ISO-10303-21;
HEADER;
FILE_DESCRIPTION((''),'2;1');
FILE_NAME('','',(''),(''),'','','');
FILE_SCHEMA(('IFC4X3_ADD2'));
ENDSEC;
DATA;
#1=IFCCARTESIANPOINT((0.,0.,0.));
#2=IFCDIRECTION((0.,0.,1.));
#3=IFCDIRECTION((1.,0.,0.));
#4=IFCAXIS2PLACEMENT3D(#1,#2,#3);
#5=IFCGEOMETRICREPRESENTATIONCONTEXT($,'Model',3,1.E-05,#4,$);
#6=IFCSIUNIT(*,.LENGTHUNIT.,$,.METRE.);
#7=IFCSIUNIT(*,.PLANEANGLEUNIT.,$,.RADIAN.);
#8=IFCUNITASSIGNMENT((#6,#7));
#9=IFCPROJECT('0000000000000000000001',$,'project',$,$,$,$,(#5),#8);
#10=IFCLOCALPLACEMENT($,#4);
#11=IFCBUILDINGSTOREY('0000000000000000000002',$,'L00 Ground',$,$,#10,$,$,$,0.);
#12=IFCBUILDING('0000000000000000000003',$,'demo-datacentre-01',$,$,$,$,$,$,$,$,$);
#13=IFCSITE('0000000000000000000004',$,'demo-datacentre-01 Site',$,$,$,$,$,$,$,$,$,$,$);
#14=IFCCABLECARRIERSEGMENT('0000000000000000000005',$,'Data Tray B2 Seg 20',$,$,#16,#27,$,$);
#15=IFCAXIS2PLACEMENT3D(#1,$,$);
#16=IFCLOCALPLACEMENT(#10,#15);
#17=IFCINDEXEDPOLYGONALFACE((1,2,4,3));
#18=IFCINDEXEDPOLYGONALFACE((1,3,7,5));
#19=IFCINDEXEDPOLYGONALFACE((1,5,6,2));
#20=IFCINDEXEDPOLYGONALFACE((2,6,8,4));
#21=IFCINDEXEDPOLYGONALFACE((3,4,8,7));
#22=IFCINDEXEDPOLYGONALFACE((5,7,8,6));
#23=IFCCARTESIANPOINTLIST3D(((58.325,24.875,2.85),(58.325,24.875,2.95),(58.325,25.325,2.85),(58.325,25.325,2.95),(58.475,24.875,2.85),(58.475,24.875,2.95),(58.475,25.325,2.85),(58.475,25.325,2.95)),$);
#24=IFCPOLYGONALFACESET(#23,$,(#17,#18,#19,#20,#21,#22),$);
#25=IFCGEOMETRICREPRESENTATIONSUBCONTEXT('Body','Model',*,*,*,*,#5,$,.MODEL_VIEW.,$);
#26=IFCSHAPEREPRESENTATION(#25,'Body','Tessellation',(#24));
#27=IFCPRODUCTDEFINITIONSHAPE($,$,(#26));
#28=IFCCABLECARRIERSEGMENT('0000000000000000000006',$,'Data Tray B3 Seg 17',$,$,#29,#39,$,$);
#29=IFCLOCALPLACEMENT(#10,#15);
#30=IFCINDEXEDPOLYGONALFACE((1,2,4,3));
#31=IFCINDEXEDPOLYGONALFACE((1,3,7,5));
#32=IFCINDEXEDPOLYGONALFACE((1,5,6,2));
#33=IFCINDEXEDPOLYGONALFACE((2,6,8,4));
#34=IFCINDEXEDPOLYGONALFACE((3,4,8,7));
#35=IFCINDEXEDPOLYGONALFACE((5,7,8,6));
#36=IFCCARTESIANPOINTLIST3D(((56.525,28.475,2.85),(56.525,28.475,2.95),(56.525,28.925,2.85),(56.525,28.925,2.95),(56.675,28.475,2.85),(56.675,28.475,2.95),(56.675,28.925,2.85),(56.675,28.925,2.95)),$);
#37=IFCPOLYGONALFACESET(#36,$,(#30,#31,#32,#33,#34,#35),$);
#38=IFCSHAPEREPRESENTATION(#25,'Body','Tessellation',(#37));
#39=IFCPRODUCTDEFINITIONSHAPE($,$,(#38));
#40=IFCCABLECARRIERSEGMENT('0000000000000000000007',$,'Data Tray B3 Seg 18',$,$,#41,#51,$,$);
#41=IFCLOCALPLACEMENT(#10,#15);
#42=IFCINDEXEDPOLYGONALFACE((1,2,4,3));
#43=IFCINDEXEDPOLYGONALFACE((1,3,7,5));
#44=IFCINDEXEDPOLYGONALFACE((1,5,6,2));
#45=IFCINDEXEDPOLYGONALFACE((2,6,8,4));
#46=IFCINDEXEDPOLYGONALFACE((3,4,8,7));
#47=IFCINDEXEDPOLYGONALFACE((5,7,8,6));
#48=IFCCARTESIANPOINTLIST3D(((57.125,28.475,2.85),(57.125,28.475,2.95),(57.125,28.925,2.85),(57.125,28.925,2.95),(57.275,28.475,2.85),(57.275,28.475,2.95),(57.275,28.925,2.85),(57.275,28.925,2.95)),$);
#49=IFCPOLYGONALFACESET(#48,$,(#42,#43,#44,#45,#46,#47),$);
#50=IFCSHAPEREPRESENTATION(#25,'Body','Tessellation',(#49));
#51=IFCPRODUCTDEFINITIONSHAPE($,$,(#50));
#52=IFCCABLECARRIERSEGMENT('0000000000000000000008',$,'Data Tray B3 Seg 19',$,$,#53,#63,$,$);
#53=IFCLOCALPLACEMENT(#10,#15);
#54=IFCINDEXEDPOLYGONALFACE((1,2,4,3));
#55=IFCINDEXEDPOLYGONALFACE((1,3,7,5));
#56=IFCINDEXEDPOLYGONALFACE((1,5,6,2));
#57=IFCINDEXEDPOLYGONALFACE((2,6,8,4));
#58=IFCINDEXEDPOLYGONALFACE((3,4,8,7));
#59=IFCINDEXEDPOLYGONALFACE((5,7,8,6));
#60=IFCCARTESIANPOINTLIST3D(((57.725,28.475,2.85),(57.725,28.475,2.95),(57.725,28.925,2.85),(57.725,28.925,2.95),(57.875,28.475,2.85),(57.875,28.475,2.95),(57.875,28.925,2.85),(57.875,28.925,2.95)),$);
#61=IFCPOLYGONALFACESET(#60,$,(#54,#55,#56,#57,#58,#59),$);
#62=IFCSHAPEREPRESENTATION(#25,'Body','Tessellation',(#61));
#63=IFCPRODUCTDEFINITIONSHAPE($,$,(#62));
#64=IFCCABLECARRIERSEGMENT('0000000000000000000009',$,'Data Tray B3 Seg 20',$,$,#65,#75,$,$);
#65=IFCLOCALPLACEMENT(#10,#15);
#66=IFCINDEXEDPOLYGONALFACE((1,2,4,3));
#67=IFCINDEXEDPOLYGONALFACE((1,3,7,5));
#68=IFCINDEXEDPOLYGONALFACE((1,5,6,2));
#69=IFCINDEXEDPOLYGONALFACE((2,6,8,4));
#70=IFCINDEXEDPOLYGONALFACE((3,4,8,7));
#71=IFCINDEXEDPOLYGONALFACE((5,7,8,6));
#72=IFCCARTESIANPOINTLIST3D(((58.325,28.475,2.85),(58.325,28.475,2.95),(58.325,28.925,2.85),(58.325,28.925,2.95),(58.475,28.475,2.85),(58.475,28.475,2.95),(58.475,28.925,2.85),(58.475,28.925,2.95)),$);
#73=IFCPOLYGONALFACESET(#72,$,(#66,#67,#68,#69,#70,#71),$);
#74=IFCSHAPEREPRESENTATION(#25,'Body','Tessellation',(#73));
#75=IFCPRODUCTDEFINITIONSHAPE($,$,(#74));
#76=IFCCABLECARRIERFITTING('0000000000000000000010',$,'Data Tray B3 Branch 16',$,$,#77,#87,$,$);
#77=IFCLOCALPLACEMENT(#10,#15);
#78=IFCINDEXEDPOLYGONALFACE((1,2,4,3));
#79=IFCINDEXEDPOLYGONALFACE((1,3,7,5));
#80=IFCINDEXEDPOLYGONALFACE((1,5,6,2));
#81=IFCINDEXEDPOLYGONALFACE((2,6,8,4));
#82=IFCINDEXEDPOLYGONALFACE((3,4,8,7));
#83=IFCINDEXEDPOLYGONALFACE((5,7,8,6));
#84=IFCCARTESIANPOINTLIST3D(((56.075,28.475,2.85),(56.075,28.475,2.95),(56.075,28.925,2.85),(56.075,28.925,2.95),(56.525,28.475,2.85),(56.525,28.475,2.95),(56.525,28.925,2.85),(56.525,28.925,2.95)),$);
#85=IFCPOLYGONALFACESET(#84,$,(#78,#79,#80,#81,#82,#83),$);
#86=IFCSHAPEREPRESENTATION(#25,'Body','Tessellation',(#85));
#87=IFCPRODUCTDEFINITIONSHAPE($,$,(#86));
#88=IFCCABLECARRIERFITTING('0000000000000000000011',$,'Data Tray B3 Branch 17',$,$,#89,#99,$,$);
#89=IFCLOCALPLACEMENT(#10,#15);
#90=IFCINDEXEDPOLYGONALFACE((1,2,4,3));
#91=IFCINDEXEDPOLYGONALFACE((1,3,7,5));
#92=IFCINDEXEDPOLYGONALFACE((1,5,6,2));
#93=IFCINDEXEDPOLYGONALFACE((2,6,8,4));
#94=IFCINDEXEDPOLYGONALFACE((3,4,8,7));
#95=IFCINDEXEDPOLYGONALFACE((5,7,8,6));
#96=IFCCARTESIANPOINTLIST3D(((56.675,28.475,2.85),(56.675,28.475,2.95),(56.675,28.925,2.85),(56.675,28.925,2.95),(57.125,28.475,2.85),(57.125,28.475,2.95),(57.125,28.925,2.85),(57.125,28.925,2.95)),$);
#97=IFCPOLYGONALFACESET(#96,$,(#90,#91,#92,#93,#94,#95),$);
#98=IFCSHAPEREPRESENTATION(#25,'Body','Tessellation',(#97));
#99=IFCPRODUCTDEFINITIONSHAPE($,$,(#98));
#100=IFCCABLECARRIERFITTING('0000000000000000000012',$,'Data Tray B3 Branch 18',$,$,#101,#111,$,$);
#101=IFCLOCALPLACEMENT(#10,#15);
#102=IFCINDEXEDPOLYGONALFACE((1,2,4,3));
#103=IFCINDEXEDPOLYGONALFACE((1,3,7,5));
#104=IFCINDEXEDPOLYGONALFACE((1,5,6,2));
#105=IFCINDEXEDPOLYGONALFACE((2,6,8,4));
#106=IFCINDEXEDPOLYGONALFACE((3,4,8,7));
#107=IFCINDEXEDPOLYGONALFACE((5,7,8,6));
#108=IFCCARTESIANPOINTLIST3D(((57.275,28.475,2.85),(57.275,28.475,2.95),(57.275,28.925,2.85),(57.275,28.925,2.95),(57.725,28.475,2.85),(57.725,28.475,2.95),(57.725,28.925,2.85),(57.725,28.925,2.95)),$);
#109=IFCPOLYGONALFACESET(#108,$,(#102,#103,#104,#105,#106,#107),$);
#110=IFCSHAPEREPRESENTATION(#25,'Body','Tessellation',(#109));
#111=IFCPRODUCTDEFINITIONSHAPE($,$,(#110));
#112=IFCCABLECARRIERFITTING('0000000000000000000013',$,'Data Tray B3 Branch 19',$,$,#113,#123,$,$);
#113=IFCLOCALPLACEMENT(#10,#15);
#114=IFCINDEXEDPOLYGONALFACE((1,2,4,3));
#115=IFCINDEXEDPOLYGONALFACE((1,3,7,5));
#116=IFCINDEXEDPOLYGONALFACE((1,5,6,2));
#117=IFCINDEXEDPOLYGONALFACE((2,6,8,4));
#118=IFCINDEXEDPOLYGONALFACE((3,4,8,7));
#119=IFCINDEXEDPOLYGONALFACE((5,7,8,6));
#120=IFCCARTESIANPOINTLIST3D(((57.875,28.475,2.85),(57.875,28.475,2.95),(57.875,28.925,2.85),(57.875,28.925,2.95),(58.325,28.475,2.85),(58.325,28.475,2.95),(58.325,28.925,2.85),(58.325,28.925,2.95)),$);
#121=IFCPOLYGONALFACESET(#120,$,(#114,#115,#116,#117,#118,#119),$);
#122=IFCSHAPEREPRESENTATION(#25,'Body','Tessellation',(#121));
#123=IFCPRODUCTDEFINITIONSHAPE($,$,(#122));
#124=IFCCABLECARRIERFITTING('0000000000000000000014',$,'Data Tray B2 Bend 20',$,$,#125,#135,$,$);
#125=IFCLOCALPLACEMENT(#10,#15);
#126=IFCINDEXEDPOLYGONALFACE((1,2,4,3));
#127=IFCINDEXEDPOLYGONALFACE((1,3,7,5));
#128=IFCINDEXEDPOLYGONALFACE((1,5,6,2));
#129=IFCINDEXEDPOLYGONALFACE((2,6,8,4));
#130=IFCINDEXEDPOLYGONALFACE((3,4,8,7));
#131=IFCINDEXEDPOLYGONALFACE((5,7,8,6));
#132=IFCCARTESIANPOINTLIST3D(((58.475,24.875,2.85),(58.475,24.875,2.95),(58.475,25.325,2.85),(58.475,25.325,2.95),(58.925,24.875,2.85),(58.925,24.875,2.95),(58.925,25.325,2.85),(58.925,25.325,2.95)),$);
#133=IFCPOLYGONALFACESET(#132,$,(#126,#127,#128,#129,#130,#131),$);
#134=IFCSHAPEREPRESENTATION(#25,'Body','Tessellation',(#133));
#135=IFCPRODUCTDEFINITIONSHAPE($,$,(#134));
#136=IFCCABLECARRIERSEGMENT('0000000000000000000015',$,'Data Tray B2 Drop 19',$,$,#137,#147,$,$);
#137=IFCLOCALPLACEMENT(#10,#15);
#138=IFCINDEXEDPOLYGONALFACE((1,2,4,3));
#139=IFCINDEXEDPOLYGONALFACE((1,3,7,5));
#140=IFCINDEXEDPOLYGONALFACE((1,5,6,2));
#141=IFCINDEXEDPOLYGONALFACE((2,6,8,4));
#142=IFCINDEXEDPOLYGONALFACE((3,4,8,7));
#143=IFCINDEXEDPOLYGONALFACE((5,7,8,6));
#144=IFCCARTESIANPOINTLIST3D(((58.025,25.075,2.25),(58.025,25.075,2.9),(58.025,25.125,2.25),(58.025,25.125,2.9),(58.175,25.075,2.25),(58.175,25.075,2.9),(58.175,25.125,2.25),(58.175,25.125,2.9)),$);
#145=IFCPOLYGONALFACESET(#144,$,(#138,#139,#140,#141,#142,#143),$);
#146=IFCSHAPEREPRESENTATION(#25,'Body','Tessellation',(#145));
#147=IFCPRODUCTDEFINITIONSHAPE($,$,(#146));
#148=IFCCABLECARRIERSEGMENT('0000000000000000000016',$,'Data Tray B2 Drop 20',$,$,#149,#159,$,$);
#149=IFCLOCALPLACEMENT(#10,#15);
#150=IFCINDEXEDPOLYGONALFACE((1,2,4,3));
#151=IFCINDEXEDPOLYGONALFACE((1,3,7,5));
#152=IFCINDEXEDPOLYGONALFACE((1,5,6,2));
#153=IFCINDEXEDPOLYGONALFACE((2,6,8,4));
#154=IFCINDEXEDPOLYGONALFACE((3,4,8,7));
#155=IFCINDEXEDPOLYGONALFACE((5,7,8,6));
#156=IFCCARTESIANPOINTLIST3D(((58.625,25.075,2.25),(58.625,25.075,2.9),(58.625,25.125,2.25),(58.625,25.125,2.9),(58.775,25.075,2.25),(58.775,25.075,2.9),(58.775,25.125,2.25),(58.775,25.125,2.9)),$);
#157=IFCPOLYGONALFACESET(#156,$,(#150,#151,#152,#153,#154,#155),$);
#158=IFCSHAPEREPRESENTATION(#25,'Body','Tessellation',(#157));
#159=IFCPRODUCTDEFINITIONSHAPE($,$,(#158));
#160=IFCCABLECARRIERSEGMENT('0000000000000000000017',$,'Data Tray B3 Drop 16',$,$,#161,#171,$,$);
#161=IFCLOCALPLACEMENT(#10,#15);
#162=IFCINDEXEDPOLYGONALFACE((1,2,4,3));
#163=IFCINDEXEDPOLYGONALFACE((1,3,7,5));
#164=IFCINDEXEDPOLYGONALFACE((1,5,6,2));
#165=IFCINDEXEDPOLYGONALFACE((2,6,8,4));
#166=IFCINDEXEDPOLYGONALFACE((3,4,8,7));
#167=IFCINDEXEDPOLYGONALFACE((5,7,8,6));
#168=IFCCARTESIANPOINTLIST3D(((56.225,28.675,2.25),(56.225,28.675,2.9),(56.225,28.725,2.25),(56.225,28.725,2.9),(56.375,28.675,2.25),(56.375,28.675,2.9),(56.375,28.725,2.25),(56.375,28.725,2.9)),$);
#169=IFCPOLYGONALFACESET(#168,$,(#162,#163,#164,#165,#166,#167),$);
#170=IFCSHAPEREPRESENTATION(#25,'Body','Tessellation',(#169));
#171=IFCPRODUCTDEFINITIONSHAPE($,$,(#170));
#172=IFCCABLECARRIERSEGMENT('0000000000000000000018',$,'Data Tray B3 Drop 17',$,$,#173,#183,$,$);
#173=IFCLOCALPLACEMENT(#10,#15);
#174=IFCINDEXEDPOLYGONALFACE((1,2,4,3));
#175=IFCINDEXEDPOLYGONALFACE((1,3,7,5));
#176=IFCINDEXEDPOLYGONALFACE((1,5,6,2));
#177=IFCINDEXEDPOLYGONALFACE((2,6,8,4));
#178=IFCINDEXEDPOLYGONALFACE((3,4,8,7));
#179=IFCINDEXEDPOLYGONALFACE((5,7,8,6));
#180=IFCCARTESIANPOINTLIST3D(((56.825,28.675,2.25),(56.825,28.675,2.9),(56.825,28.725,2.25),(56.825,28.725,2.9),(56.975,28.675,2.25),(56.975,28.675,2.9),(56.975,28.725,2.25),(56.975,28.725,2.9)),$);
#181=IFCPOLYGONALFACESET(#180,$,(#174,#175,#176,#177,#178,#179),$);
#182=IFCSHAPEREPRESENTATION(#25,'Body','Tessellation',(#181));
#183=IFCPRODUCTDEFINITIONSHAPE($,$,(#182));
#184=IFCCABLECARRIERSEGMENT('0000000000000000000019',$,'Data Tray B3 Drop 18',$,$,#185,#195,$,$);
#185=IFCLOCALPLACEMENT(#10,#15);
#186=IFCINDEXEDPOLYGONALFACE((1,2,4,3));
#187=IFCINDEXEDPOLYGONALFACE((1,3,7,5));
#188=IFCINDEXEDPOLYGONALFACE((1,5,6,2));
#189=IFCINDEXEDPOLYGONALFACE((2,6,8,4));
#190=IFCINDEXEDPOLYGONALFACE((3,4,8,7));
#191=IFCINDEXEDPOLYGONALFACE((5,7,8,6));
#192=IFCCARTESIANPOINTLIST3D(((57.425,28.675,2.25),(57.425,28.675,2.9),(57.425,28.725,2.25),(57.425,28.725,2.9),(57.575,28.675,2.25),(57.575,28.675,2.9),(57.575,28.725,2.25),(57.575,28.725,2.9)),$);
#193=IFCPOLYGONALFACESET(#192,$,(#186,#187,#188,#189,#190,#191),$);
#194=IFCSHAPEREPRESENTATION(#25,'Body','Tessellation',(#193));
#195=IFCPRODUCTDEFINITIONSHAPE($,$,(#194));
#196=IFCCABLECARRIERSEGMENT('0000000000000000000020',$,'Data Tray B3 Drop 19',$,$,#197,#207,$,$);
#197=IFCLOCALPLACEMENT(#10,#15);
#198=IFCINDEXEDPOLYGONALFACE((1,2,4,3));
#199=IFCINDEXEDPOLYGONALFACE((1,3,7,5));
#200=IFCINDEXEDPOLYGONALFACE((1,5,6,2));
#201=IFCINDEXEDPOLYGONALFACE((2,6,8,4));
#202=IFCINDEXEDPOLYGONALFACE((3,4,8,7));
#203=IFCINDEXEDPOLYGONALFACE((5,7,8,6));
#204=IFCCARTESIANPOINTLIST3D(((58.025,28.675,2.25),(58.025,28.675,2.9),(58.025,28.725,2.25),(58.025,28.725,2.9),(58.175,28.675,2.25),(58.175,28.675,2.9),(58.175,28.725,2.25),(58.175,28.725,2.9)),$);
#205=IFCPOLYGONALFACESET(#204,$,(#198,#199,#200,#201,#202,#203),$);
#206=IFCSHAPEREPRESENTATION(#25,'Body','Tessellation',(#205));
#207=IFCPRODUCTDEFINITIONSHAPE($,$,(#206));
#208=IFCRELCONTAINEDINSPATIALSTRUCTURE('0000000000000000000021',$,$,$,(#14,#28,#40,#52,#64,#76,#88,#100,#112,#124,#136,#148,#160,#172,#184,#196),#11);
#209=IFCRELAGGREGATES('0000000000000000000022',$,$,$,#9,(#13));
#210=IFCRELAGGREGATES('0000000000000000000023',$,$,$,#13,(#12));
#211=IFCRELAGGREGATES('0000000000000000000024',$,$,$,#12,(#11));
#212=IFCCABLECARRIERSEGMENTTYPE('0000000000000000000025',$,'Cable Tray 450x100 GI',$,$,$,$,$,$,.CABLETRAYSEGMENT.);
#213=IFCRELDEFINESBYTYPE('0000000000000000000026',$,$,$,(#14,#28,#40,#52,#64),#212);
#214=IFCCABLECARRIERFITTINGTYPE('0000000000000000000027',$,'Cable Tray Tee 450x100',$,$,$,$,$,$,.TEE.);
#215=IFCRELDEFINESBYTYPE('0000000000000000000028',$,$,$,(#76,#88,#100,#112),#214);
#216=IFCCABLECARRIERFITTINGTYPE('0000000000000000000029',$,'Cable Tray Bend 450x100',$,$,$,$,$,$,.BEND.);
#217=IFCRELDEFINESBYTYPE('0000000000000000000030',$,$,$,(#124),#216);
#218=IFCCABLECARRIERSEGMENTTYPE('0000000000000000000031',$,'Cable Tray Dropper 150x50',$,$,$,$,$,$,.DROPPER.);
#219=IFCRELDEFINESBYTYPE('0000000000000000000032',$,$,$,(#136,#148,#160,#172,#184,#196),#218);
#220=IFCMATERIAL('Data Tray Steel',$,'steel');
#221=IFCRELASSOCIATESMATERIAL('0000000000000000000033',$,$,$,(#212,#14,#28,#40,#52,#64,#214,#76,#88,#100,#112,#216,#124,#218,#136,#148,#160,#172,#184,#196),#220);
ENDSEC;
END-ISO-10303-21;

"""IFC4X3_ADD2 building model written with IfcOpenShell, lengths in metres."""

from ifc_helpers import new_model, si_unit, frame, origin_with_axes, place, context, subcontext, project, spatial, rectangle, extrude, material, type_object, element, save


model = new_model("IFC4X3_ADD2")

# Units and contexts
model_context = context("Model", 3, precision=1e-05, world=origin_with_axes())
body_context = subcontext(model_context, "Body", "Model", "MODEL_VIEW")
ifc_project = project(units=[si_unit("LENGTHUNIT", "METRE"), si_unit("PLANEANGLEUNIT", "RADIAN")], contexts=[model_context])

# Site, building, storey
site = spatial("IfcSite", under=ifc_project, Name="demo-datacentre-01 Site")
building = spatial("IfcBuilding", under=site, Name="demo-datacentre-01")
storey_placement = place(None, origin_with_axes())
storey = spatial("IfcBuildingStorey", under=building, at=storey_placement, Name="L00 Ground", Elevation=0.0)

# Cable carrier segments
ifc_material_1 = material(Name="Data Tray Steel", Category="steel")
cable_carrier_segment_type_1 = type_object("IfcCableCarrierSegmentType", Name="Cable Tray 450x100 GI", PredefinedType="CABLETRAYSEGMENT", material=ifc_material_1)
for number, where, z_axis, x_axis, name in (
    (1, (58.325, 25.1, 2.9), (1.0, 0.0, 0.0), (0.0, 1.0, 0.0), "Data Tray B2 Seg 20"),
    (2, (56.525, 28.7, 2.9), (1.0, 0.0, 0.0), (0.0, 1.0, 0.0), "Data Tray B3 Seg 17"),
    (3, (57.125, 28.7, 2.9), (1.0, 0.0, 0.0), (0.0, 1.0, 0.0), "Data Tray B3 Seg 18"),
):
    element("IfcCableCarrierSegment", number, at=place(storey_placement, frame(where, z_axis=z_axis, x_axis=x_axis)), inside=storey, type_object=cable_carrier_segment_type_1, material=ifc_material_1, Name=name, context=body_context, shape_type="SweptSolid", body=[
        extrude(rectangle(XDim=0.45, YDim=0.1), origin_with_axes(), (0.0, 0.0, 1.0), 0.15),
    ])
cable_carrier_segment_1_placement = place(storey_placement, frame((57.725, 28.7, 2.9), z_axis=(1.0, 0.0, 0.0), x_axis=(0.0, 1.0, 0.0)))
element("IfcCableCarrierSegment", 4, at=cable_carrier_segment_1_placement, inside=storey, type_object=cable_carrier_segment_type_1, material=ifc_material_1, Name="Data Tray B3 Seg 19", context=body_context, shape_type="SweptSolid", body=[
    extrude(rectangle(XDim=0.45, YDim=0.1), origin_with_axes(), (0.0, 0.0, 1.0), 0.15),
])
cable_carrier_segment_2_placement = place(storey_placement, frame((58.325, 28.7, 2.9), z_axis=(1.0, 0.0, 0.0), x_axis=(0.0, 1.0, 0.0)))
element("IfcCableCarrierSegment", 5, at=cable_carrier_segment_2_placement, inside=storey, type_object=cable_carrier_segment_type_1, material=ifc_material_1, Name="Data Tray B3 Seg 20", context=body_context, shape_type="SweptSolid", body=[
    extrude(rectangle(XDim=0.45, YDim=0.1), origin_with_axes(), (0.0, 0.0, 1.0), 0.15),
])

# Cable carrier fittings
cable_carrier_fitting_type_1 = type_object("IfcCableCarrierFittingType", Name="Cable Tray Tee 450x100", PredefinedType="TEE", material=ifc_material_1)
for number, where, z_axis, x_axis, name in (
    (6, (56.3, 28.7, 2.85), (0.0, 0.0, 1.0), (1.0, 0.0, 0.0), "Data Tray B3 Branch 16"),
    (7, (56.9, 28.7, 2.85), (0.0, 0.0, 1.0), (1.0, 0.0, 0.0), "Data Tray B3 Branch 17"),
    (8, (57.5, 28.7, 2.85), (0.0, 0.0, 1.0), (1.0, 0.0, 0.0), "Data Tray B3 Branch 18"),
    (9, (58.1, 28.7, 2.85), (0.0, 0.0, 1.0), (1.0, 0.0, 0.0), "Data Tray B3 Branch 19"),
):
    element("IfcCableCarrierFitting", number, at=place(storey_placement, frame(where, z_axis=z_axis, x_axis=x_axis)), inside=storey, type_object=cable_carrier_fitting_type_1, material=ifc_material_1, Name=name, context=body_context, shape_type="SweptSolid", body=[
        extrude(rectangle(XDim=0.45, YDim=0.45), origin_with_axes(), (0.0, 0.0, 1.0), 0.1),
    ])
cable_carrier_fitting_type_2 = type_object("IfcCableCarrierFittingType", Name="Cable Tray Bend 450x100", PredefinedType="BEND", material=ifc_material_1)
cable_carrier_fitting_placement = place(storey_placement, frame((58.7, 25.1, 2.85), z_axis=(0.0, 0.0, 1.0), x_axis=(1.0, 0.0, 0.0)))
element("IfcCableCarrierFitting", 10, at=cable_carrier_fitting_placement, inside=storey, type_object=cable_carrier_fitting_type_2, material=ifc_material_1, Name="Data Tray B2 Bend 20", context=body_context, shape_type="SweptSolid", body=[
    extrude(rectangle(XDim=0.45, YDim=0.45), origin_with_axes(), (0.0, 0.0, 1.0), 0.1),
])

# Cable carrier segments
cable_carrier_segment_type_2 = type_object("IfcCableCarrierSegmentType", Name="Cable Tray Dropper 150x50", PredefinedType="DROPPER", material=ifc_material_1)
for number, where, z_axis, x_axis, name in (
    (11, (58.1, 25.1, 2.9), (0.0, 0.0, -1.0), (1.0, 0.0, 0.0), "Data Tray B2 Drop 19"),
    (12, (58.7, 25.1, 2.9), (0.0, 0.0, -1.0), (1.0, 0.0, 0.0), "Data Tray B2 Drop 20"),
    (13, (56.3, 28.7, 2.9), (0.0, 0.0, -1.0), (1.0, 0.0, 0.0), "Data Tray B3 Drop 16"),
    (14, (56.9, 28.7, 2.9), (0.0, 0.0, -1.0), (1.0, 0.0, 0.0), "Data Tray B3 Drop 17"),
    (15, (57.5, 28.7, 2.9), (0.0, 0.0, -1.0), (1.0, 0.0, 0.0), "Data Tray B3 Drop 18"),
    (16, (58.1, 28.7, 2.9), (0.0, 0.0, -1.0), (1.0, 0.0, 0.0), "Data Tray B3 Drop 19"),
):
    element("IfcCableCarrierSegment", number, at=place(storey_placement, frame(where, z_axis=z_axis, x_axis=x_axis)), inside=storey, type_object=cable_carrier_segment_type_2, material=ifc_material_1, Name=name, context=body_context, shape_type="SweptSolid", body=[
        extrude(rectangle(XDim=0.15, YDim=0.05), origin_with_axes(), (0.0, 0.0, 1.0), 0.65),
    ])

save(model, "model.ifc")
